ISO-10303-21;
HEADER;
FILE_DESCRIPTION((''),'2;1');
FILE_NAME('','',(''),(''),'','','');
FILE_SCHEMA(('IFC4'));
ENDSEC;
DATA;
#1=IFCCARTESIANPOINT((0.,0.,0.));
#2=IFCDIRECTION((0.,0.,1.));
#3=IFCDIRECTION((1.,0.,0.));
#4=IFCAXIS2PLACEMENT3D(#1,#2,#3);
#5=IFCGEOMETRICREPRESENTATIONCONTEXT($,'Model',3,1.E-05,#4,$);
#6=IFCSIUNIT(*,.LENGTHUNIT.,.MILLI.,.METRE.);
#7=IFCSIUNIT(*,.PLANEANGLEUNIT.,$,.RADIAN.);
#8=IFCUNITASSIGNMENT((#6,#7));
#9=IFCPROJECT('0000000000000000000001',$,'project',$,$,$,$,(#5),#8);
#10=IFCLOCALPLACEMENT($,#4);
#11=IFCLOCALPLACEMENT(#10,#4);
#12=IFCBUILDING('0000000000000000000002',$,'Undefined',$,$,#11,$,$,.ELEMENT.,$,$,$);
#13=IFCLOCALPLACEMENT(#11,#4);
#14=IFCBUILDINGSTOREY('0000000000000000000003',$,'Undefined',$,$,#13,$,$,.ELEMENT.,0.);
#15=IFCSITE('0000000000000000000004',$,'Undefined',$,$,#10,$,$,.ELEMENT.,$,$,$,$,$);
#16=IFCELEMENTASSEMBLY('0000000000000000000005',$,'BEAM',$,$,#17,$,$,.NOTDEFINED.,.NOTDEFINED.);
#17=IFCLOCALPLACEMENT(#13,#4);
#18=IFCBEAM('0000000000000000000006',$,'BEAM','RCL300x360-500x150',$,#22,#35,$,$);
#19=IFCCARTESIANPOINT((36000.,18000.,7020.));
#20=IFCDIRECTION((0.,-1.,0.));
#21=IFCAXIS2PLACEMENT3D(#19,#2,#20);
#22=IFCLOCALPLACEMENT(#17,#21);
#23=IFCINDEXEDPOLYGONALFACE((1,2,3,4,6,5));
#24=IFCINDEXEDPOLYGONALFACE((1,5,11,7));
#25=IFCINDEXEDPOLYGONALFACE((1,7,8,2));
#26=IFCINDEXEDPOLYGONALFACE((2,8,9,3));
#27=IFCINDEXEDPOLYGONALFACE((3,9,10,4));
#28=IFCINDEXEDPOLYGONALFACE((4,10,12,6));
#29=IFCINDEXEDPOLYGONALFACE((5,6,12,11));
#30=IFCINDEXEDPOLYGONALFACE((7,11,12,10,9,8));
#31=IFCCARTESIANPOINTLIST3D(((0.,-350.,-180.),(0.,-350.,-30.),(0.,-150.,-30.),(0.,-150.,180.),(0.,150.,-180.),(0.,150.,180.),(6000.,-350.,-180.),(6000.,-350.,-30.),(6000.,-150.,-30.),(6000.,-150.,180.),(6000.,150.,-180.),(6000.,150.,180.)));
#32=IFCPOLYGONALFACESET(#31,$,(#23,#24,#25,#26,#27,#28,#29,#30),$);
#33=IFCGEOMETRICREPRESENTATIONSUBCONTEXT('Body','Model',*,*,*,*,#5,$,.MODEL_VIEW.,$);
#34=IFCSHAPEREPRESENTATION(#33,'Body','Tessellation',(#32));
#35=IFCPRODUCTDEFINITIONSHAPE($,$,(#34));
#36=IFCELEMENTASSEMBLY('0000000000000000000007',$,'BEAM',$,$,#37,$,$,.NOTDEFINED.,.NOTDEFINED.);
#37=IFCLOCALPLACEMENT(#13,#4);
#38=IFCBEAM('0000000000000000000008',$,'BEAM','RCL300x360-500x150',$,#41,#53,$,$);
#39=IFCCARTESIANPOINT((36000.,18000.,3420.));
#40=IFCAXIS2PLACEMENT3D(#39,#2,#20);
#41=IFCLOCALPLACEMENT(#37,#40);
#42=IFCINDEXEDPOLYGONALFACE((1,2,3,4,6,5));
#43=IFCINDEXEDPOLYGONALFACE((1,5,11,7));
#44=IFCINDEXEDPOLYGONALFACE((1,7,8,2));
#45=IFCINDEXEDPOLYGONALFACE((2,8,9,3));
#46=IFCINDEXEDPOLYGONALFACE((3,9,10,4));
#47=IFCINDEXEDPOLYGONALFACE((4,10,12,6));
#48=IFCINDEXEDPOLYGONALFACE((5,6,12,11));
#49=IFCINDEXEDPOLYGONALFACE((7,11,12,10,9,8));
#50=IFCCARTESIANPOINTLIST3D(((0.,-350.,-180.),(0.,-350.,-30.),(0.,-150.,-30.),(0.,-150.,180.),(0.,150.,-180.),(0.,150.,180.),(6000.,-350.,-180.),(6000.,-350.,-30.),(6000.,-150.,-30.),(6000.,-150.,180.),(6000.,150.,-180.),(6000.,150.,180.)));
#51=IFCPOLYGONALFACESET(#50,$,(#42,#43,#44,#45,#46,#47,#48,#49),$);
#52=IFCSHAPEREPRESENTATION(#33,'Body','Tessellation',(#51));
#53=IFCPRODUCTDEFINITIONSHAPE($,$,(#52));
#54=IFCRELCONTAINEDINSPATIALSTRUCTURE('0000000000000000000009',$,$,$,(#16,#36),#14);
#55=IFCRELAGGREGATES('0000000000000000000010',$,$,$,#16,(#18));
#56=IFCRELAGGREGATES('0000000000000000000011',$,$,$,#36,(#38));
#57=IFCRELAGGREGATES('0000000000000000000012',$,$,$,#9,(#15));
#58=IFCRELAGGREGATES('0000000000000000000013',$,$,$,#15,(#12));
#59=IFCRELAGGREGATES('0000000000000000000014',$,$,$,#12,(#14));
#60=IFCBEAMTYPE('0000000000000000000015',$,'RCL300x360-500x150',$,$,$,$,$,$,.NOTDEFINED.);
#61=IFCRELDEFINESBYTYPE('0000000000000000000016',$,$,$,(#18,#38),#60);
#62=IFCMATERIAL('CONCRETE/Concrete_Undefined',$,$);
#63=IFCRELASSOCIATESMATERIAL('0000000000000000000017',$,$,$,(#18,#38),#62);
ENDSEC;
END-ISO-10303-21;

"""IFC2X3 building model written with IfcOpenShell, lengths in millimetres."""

from ifc_helpers import new_model, si_unit, frame, origin_with_axes, place, context, subcontext, project, spatial, polyline, outline, extrude, material, type_object, element, aggregate, save


model = new_model("IFC2X3")

# Units and contexts
model_context = context("Model", 3, precision=1e-05, world=origin_with_axes())
body_context = subcontext(model_context, "Body", "Model", "MODEL_VIEW")
ifc_project = project(units=[si_unit("LENGTHUNIT", "METRE", prefix="MILLI"), si_unit("PLANEANGLEUNIT", "RADIAN")], contexts=[model_context])

# Site, building, storey
site_placement = place(None, origin_with_axes())
site = spatial("IfcSite", under=ifc_project, at=site_placement, Name="Undefined", CompositionType="ELEMENT")
building_placement = place(site_placement, origin_with_axes())
building = spatial("IfcBuilding", under=site, at=building_placement, Name="Undefined", CompositionType="ELEMENT")
storey_placement = place(building_placement, origin_with_axes())
storey = spatial("IfcBuildingStorey", under=building, at=storey_placement, Name="Undefined", CompositionType="ELEMENT", Elevation=0.0)

# Shared definitions
ifc_material = material(Name="CONCRETE/Concrete_Undefined")

# Element assemblies, beams
assembly_1_placement = place(storey_placement, origin_with_axes())
assembly_1 = element("IfcElementAssembly", 1, at=assembly_1_placement, inside=storey, Name="BEAM", AssemblyPlace="NOTDEFINED", PredefinedType="NOTDEFINED")
beam_type = type_object("IfcBeamType", Name="RCL300x360-500x150", PredefinedType="NOTDEFINED")
beam_1_placement = place(assembly_1_placement, frame((36000.0, 18000.0, 7020.0), z_axis=(0.0, 0.0, 1.0), x_axis=(0.0, -1.0, 0.0)))
beam_1 = element("IfcBeam", 2, at=beam_1_placement, type_object=beam_type, material=ifc_material, Name="BEAM", Description="RCL300x360-500x150", context=body_context, shape_type="SweptSolid", body=[
    extrude(outline(polyline([(350.0, -180.0), (-150.0, -180.0), (-150.0, 180.0), (150.0, 180.0), (150.0, -30.0), (350.0, -30.0), (350.0, -180.0)])), frame((6000.0, 0.0, 0.0), z_axis=(-1.0, 0.0, 0.0), x_axis=(0.0, -1.0, 0.0)), (0.0, 0.0, 1.0), 6000.0),
])
aggregate(assembly_1, [beam_1])
assembly_2_placement = place(storey_placement, origin_with_axes())
assembly_2 = element("IfcElementAssembly", 3, at=assembly_2_placement, inside=storey, Name="BEAM", AssemblyPlace="NOTDEFINED", PredefinedType="NOTDEFINED")
beam_2_placement = place(assembly_2_placement, frame((36000.0, 18000.0, 3420.0), z_axis=(0.0, 0.0, 1.0), x_axis=(0.0, -1.0, 0.0)))
beam_2 = element("IfcBeam", 4, at=beam_2_placement, type_object=beam_type, material=ifc_material, Name="BEAM", Description="RCL300x360-500x150", context=body_context, shape_type="SweptSolid", body=[
    extrude(outline(polyline([(350.0, -180.0), (-150.0, -180.0), (-150.0, 180.0), (150.0, 180.0), (150.0, -30.0), (350.0, -30.0), (350.0, -180.0)])), frame((6000.0, 0.0, 0.0), z_axis=(-1.0, 0.0, 0.0), x_axis=(0.0, -1.0, 0.0)), (0.0, 0.0, 1.0), 6000.0),
])
aggregate(assembly_2, [beam_2])

save(model, "model.ifc")
